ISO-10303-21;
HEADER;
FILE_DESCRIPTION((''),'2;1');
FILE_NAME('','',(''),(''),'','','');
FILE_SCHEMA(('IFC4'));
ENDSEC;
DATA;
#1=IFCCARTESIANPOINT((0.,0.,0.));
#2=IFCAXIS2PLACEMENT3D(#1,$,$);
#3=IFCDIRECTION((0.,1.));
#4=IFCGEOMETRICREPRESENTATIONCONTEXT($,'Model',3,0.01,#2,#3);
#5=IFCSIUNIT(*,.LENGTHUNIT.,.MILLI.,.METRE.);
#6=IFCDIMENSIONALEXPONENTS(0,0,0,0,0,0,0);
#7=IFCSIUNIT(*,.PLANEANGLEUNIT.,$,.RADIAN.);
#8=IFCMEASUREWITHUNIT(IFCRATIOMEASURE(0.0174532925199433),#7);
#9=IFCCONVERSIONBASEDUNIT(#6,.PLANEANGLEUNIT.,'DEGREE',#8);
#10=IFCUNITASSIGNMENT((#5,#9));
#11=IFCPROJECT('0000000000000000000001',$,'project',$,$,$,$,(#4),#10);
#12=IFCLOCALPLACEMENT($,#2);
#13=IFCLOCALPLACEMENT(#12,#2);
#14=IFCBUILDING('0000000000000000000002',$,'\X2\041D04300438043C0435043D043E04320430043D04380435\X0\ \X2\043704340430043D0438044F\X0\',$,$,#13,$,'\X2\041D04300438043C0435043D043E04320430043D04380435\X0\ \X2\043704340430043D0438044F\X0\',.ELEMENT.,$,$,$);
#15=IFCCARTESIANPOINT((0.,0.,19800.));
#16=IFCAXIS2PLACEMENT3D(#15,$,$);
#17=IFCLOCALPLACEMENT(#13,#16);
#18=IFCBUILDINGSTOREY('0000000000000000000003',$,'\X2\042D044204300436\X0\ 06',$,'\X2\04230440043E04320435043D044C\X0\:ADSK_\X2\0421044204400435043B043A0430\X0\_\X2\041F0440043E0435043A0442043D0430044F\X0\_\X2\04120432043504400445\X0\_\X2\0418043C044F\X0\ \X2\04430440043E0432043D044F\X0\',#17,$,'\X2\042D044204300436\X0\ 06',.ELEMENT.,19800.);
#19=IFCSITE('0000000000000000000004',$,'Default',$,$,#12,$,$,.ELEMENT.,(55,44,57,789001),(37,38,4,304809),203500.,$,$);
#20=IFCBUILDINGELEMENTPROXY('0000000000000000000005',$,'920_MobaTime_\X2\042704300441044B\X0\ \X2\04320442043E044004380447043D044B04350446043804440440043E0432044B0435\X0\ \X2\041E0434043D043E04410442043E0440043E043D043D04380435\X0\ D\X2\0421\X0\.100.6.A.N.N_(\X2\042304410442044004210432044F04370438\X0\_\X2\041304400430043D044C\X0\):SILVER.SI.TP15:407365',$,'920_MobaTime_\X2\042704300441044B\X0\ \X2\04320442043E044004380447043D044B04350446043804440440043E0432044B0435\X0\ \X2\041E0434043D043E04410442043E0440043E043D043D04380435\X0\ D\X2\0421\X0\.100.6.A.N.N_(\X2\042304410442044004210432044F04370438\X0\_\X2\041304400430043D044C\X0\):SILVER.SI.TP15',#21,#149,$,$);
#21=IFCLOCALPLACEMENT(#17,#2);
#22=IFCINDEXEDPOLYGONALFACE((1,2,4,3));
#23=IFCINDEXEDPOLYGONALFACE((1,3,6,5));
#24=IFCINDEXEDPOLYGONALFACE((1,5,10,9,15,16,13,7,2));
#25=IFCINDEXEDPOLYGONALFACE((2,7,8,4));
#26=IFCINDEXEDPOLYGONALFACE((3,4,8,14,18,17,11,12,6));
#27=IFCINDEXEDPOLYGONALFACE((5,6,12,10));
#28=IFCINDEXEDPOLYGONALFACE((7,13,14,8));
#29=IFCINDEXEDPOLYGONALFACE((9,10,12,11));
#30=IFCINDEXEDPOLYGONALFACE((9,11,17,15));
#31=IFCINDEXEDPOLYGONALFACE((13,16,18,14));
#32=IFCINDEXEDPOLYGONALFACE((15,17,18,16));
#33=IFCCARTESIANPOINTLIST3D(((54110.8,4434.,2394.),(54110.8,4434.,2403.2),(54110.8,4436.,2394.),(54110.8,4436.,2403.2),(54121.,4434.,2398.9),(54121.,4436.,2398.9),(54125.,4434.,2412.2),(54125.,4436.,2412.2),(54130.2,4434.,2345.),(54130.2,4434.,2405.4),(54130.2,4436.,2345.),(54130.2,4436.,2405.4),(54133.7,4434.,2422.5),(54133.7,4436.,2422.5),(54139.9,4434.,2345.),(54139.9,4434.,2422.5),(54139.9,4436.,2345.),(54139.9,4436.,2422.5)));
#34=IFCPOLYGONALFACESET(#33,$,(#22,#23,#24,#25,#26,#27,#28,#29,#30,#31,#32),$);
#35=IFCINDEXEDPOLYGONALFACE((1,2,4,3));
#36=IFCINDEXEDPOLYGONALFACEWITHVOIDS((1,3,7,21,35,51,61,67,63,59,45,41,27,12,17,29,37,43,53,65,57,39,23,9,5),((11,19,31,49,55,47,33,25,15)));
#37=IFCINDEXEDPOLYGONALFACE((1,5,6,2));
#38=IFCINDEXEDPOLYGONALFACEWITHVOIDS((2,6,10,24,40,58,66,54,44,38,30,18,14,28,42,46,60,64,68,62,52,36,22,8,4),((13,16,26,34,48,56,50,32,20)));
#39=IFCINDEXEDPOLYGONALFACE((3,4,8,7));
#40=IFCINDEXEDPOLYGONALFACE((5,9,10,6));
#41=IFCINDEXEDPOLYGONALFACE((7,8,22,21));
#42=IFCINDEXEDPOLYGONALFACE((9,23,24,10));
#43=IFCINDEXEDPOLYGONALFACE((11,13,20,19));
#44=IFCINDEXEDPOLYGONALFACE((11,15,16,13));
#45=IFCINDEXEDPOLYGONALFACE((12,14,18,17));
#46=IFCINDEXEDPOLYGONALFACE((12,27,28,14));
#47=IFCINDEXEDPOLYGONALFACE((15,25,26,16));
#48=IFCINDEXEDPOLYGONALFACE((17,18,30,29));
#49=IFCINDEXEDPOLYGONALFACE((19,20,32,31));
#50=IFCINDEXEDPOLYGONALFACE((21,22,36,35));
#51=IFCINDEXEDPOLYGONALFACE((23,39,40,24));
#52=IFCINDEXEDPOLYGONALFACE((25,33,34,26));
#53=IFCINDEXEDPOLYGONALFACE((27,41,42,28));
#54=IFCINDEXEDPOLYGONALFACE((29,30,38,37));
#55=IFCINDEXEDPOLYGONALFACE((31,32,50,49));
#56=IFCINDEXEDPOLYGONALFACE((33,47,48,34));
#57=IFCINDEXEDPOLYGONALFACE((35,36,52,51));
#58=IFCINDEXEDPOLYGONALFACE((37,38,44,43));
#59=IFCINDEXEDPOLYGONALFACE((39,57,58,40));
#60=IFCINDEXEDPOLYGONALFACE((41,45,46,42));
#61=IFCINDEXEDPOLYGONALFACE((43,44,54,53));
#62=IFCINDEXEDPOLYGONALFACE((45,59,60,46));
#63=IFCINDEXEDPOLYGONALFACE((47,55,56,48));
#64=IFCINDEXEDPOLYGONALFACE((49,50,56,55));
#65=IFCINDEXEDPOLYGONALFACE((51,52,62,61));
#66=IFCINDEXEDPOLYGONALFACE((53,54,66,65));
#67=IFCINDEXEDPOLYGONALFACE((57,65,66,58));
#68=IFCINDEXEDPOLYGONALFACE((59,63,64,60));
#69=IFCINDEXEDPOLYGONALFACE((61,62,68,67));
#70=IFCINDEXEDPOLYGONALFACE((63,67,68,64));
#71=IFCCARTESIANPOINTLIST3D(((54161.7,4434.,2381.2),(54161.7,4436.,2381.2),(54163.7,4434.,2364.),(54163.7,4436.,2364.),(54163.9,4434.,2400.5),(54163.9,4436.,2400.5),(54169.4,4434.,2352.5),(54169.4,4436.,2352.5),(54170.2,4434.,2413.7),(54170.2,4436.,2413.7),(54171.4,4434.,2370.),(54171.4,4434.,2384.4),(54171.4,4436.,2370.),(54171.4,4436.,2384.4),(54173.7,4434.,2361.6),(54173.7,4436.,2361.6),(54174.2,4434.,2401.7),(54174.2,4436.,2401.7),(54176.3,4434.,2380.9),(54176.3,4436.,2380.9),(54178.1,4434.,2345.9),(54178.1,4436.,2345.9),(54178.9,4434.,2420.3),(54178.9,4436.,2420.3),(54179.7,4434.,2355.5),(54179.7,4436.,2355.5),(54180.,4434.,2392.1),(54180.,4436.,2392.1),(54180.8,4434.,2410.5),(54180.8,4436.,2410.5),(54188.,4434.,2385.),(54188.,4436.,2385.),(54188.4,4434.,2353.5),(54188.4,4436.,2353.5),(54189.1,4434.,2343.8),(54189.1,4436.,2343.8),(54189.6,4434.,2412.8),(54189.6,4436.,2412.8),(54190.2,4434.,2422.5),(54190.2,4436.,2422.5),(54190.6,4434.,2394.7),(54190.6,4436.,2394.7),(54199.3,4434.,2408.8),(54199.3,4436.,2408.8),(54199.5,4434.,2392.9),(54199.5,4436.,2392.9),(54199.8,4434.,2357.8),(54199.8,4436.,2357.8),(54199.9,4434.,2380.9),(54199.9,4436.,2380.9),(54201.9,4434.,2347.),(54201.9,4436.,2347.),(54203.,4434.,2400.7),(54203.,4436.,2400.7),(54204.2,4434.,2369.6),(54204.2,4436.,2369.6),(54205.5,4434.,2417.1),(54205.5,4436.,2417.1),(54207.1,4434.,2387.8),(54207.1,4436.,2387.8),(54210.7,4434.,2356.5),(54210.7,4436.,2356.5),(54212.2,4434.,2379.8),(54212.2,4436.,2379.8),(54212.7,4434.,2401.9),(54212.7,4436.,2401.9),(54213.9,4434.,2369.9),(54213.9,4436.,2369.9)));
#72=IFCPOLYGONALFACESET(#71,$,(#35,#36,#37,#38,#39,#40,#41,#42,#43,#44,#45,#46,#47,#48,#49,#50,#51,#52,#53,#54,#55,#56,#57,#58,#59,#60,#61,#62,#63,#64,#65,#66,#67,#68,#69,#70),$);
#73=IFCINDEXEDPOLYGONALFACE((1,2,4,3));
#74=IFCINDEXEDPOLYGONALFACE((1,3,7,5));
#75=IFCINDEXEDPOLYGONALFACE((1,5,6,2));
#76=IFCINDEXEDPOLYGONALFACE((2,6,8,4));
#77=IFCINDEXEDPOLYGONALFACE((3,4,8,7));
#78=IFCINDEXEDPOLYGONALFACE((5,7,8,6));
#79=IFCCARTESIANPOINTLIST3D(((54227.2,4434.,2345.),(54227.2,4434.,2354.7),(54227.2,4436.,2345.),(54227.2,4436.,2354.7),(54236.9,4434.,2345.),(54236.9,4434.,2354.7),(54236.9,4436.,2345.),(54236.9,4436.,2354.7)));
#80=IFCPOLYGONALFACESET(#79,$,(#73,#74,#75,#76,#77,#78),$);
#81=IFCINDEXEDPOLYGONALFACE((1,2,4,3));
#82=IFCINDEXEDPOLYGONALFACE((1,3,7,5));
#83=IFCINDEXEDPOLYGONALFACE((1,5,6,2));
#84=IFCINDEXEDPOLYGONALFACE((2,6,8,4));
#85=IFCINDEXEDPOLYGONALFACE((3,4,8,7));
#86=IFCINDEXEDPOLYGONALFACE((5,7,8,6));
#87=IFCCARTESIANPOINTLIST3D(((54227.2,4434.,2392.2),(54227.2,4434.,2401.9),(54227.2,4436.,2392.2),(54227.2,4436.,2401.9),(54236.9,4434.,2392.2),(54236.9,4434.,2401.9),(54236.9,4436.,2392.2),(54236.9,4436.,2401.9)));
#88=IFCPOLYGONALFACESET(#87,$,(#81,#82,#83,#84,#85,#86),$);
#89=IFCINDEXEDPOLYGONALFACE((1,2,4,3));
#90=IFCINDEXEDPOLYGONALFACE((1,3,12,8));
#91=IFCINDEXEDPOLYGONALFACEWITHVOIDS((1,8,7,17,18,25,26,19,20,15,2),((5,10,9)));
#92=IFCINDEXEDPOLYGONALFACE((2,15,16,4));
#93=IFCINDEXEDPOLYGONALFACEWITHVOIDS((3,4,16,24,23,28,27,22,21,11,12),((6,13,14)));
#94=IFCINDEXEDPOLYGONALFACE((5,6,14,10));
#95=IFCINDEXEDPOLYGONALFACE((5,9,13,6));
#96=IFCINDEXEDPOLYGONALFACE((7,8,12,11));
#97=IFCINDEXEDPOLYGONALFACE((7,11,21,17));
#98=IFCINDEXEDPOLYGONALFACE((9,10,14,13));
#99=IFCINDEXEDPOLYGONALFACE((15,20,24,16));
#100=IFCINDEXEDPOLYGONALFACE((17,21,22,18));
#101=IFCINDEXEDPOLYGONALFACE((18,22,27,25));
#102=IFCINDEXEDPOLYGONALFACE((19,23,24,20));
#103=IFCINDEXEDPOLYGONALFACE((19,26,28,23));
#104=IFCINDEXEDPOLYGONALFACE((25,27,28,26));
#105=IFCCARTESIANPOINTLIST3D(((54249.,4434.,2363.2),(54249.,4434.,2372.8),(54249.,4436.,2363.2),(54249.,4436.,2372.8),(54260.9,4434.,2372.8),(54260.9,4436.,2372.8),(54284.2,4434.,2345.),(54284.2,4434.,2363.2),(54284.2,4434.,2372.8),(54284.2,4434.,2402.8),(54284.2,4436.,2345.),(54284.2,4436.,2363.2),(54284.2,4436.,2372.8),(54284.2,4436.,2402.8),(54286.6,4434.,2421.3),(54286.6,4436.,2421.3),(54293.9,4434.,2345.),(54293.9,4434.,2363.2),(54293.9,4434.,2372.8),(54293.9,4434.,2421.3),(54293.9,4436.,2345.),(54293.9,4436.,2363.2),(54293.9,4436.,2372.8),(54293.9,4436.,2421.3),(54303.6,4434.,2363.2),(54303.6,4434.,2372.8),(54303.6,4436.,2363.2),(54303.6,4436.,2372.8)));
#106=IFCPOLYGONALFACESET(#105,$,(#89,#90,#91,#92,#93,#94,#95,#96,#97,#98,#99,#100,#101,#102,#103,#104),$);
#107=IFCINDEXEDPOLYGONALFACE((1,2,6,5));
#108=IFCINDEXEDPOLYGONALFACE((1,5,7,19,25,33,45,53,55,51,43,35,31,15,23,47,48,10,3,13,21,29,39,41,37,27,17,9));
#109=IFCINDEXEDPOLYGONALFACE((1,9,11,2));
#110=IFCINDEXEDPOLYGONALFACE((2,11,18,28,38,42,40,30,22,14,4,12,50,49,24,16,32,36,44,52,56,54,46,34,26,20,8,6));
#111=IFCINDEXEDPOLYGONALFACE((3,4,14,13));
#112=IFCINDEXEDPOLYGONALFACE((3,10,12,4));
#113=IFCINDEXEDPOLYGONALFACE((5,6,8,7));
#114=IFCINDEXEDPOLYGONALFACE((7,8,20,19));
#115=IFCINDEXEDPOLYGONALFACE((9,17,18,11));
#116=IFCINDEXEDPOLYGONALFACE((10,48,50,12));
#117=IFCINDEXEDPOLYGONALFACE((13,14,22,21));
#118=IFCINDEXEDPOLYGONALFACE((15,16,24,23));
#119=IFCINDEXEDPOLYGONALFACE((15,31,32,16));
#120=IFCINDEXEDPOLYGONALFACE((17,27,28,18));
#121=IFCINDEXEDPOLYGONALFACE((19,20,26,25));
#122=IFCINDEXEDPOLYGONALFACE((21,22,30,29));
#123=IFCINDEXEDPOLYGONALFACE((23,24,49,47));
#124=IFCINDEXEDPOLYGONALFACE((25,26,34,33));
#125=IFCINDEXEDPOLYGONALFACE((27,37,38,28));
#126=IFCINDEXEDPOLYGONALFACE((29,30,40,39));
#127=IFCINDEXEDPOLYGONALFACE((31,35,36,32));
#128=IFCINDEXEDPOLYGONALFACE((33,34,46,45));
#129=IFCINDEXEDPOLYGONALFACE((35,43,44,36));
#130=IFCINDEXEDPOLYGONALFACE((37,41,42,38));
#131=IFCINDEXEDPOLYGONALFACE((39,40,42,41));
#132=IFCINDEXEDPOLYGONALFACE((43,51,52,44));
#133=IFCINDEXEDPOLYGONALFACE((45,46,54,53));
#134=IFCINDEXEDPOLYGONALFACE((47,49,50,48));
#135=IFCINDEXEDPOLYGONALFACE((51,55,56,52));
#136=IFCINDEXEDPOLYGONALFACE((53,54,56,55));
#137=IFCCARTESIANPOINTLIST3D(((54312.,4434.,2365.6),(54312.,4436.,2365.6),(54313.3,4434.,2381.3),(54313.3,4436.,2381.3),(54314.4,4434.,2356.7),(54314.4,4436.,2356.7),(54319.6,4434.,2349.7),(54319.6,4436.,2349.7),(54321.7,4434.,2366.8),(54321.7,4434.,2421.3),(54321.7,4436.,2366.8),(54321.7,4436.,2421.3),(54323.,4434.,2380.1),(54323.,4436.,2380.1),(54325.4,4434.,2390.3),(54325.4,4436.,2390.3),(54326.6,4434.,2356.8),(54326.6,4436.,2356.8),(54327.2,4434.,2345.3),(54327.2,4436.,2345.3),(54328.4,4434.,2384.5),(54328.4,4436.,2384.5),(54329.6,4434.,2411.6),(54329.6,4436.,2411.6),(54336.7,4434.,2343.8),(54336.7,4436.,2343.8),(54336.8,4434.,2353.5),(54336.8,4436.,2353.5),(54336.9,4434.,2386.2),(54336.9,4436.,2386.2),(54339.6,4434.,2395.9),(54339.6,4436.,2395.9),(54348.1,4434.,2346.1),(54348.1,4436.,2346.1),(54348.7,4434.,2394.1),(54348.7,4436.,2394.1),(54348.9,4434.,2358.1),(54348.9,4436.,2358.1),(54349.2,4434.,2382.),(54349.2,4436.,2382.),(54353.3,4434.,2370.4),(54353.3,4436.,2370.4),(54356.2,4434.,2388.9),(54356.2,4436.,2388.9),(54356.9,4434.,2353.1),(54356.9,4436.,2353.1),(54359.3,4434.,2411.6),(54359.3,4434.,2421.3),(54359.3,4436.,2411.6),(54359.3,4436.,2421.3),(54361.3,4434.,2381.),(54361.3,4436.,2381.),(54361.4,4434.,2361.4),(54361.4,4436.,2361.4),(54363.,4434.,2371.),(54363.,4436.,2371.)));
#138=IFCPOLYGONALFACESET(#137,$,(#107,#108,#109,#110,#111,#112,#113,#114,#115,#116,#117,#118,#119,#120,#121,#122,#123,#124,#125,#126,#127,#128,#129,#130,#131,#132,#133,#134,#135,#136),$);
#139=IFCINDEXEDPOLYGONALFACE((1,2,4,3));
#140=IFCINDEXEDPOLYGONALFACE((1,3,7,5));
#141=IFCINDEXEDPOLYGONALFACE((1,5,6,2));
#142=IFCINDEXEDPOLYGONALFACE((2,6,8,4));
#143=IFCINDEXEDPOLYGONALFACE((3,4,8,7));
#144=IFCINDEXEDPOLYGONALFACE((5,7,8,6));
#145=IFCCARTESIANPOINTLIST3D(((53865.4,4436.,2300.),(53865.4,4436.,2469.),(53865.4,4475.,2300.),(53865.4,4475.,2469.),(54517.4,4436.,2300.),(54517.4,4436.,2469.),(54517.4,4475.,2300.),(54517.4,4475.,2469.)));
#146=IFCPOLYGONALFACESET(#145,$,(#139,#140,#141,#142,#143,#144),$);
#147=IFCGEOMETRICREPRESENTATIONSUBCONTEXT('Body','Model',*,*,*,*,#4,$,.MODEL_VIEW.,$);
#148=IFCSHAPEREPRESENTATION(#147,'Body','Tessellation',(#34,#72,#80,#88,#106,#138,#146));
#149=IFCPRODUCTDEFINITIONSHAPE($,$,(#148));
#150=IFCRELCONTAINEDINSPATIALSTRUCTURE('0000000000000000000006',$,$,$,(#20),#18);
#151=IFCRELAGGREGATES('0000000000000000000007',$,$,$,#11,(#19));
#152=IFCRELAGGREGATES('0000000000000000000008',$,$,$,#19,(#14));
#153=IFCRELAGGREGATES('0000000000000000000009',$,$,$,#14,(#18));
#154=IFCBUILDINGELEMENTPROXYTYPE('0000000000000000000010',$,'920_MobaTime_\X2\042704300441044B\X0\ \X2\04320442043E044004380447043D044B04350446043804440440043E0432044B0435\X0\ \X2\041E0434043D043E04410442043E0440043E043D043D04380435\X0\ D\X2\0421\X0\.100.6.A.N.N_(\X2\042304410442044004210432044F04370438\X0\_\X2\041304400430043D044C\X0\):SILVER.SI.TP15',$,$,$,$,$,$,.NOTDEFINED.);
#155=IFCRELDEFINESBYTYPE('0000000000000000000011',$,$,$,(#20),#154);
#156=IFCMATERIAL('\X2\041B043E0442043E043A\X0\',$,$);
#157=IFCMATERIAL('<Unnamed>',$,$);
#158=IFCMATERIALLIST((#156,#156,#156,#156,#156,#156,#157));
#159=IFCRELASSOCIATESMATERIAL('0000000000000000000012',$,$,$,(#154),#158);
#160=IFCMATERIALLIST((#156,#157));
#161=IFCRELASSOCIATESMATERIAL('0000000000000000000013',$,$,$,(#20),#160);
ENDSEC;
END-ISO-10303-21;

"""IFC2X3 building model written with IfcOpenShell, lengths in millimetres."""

from ifc_helpers import new_model, entity, si_unit, converted_unit, direction, frame, origin, origin_2d_with_axis, place, context, subcontext, project, spatial, polyline, rectangle, outline, extrude, source, transform, mapped, material, material_list, type_object, type_shapes, element, save


model = new_model("IFC2X3")

# Units and contexts
model_context = context("Model", 3, precision=0.01, world=origin(), true_north=direction((0.0, 1.0)))
body_context = subcontext(model_context, "Body", "Model", "MODEL_VIEW")
ifc_project = project(units=[si_unit("LENGTHUNIT", "METRE", prefix="MILLI"), converted_unit("PLANEANGLEUNIT", "DEGREE", entity("IfcRatioMeasure", 0.0174532925199433), si_unit("PLANEANGLEUNIT", "RADIAN"), dimensions=[0, 0, 0, 0, 0, 0, 0])], contexts=[model_context])

# Site, building, storey
site_placement = place(None, frame((0.0, 0.0, 0.0)))
site = spatial("IfcSite", under=ifc_project, at=site_placement, Name="Default", CompositionType="ELEMENT", RefLatitude=(55, 44, 57, 789001), RefLongitude=(37, 38, 4, 304809), RefElevation=203500.0)
building_placement = place(site_placement, origin())
building = spatial("IfcBuilding", under=site, at=building_placement, Name="Наименование здания", LongName="Наименование здания", CompositionType="ELEMENT")
storey_placement = place(building_placement, frame((0.0, 0.0, 19800.0)))
storey = spatial("IfcBuildingStorey", under=building, at=storey_placement, Name="Этаж 06", ObjectType="Уровень:ADSK_Стрелка_Проектная_Вверх_Имя уровня", LongName="Этаж 06", CompositionType="ELEMENT", Elevation=19800.0)

# Building element proxy
ifc_material_1 = material(Name="Лоток")
ifc_material_2 = material(Name="<Unnamed>")
ifc_material_list_1 = material_list([ifc_material_1, ifc_material_1, ifc_material_1, ifc_material_1, ifc_material_1, ifc_material_1, ifc_material_2])
building_element_proxy_type_1 = type_object("IfcBuildingElementProxyType", Name="920_MobaTime_Часы вторичныецифровые Односторонние DС.100.6.A.N.N_(УстрСвязи_Грань):SILVER.SI.TP15", PredefinedType="NOTDEFINED", material=ifc_material_list_1)
shared_shape_1 = source(origin(), body_context, "Body", "SweptSolid", [
    extrude(outline(polyline([(-49.3, -13.1), (28.2, -13.1), (28.2, -6.8), (17.9, 1.8), (8.9, 16.0), (-0.3, 16.0), (4.6, 5.8), (11.1, -3.4), (-49.3, -3.4), (-49.3, -13.1)])), frame((-64.6, 9.8, 39.0), z_axis=(0.0, 0.0, 1.0), x_axis=(0.0, 1.0, 0.0)), (0.0, 0.0, 1.0), 2.0),
    extrude(outline(polyline([(2.2, -27.6), (19.0, -27.6), (30.5, -16.1), (33.3, -4.9), (31.0, 5.8), (21.8, 17.2), (5.2, 27.3), (-11.1, 33.0), (-24.0, 32.7), (-33.6, 27.6), (-40.3, 18.6), (-42.8, 5.7), (-38.0, -6.3), (-27.2, -15.0), (-17.5, -17.7), (-8.2, -16.4), (-0.3, -11.9), (5.1, -4.5), (7.3, 6.2), (4.0, 17.2), (18.5, 7.3), (23.6, -2.4), (22.0, -11.4), (14.2, -18.4), (5.3, -18.3), (2.2, -27.6)]), holes=[polyline([(-9.0, 23.3), (-1.3, 14.4), (-2.6, 2.0), (-11.4, -7.0), (-23.4, -6.1), (-32.2, 2.9), (-31.2, 15.1), (-25.6, 22.1), (-17.5, 24.9), (-9.0, 23.3)])]), frame((-2.7, 3.6, 39.0), z_axis=(0.0, 0.0, 1.0), x_axis=(-0.427649, 0.903945, 0.0)), (0.0, 0.0, 1.0), 2.0),
    extrude(rectangle(XDim=9.7, YDim=9.7, at=origin_2d_with_axis()), frame((40.6, -34.7, 39.0)), (0.0, 0.0, 1.0), 2.0),
    extrude(rectangle(XDim=9.7, YDim=9.7, at=origin_2d_with_axis()), frame((40.6, 12.6, 39.0)), (0.0, 0.0, 1.0), 2.0),
    extrude(outline(polyline([(-0.9, -28.1), (8.8, -28.1), (8.8, -9.9), (18.5, -9.9), (18.5, -0.2), (8.8, -0.2), (8.8, 48.3), (1.5, 48.3), (-36.0, -0.2), (-36.0, -9.9), (-0.9, -9.9), (-0.9, -28.1)]), holes=[polyline([(-0.9, -0.2), (-24.1, -0.2), (-0.9, 29.7), (-0.9, -0.2)])]), frame((93.6, -11.4, 39.0)), (0.0, 0.0, 1.0), 2.0),
    extrude(outline(polyline([(3.3, -28.3), (12.5, -28.3), (20.5, -25.0), (26.8, -18.8), (30.7, -10.0), (31.4, 1.6), (26.9, 11.8), (20.1, 18.4), (11.1, 22.3), (1.0, 23.3), (-7.9, 20.4), (-14.9, 14.5), (-18.9, 6.2), (-17.1, -9.0), (-36.7, 0.5), (-29.1, 29.3), (-38.5, 31.7), (-48.1, -4.6), (-11.6, -23.0), (-8.0, -14.0), (-10.8, -7.6), (-10.2, 1.1), (-3.0, 11.8), (9.2, 12.8), (20.0, 5.4), (21.3, -7.5), (15.5, -16.4), (4.6, -18.6), (3.3, -28.3)])), frame((147.1, -8.5, 39.0), z_axis=(0.0, 0.0, 1.0), x_axis=(0.256974, -0.966418, 0.0)), (0.0, 0.0, 1.0), 2.0),
    extrude(rectangle(XDim=652.0, YDim=169.0, at=origin_2d_with_axis()), frame((0.0, 0.0, 0.0), z_axis=(0.0, 0.0, 1.0), x_axis=(-1.0, 0.0, 0.0)), (0.0, 0.0, 1.0), 39.0),
])
type_shapes(building_element_proxy_type_1, [shared_shape_1])
ifc_material_list_2 = material_list([ifc_material_1, ifc_material_2])
proxy_1_placement = place(storey_placement, frame((54191.4, 4475.0, 2384.5), z_axis=(0.0, -1.0, 0.0), x_axis=(1.0, 0.0, 0.0)))
element("IfcBuildingElementProxy", 1, at=proxy_1_placement, inside=storey, type_object=building_element_proxy_type_1, material=ifc_material_list_2, Name="920_MobaTime_Часы вторичныецифровые Односторонние DС.100.6.A.N.N_(УстрСвязи_Грань):SILVER.SI.TP15:407365", ObjectType="920_MobaTime_Часы вторичныецифровые Односторонние DС.100.6.A.N.N_(УстрСвязи_Грань):SILVER.SI.TP15", context=body_context, shape_type="MappedRepresentation", body=[
    mapped(shared_shape_1, transform((0.0, 0.0, 0.0), scale=1.0)),
])

save(model, "model.ifc")
